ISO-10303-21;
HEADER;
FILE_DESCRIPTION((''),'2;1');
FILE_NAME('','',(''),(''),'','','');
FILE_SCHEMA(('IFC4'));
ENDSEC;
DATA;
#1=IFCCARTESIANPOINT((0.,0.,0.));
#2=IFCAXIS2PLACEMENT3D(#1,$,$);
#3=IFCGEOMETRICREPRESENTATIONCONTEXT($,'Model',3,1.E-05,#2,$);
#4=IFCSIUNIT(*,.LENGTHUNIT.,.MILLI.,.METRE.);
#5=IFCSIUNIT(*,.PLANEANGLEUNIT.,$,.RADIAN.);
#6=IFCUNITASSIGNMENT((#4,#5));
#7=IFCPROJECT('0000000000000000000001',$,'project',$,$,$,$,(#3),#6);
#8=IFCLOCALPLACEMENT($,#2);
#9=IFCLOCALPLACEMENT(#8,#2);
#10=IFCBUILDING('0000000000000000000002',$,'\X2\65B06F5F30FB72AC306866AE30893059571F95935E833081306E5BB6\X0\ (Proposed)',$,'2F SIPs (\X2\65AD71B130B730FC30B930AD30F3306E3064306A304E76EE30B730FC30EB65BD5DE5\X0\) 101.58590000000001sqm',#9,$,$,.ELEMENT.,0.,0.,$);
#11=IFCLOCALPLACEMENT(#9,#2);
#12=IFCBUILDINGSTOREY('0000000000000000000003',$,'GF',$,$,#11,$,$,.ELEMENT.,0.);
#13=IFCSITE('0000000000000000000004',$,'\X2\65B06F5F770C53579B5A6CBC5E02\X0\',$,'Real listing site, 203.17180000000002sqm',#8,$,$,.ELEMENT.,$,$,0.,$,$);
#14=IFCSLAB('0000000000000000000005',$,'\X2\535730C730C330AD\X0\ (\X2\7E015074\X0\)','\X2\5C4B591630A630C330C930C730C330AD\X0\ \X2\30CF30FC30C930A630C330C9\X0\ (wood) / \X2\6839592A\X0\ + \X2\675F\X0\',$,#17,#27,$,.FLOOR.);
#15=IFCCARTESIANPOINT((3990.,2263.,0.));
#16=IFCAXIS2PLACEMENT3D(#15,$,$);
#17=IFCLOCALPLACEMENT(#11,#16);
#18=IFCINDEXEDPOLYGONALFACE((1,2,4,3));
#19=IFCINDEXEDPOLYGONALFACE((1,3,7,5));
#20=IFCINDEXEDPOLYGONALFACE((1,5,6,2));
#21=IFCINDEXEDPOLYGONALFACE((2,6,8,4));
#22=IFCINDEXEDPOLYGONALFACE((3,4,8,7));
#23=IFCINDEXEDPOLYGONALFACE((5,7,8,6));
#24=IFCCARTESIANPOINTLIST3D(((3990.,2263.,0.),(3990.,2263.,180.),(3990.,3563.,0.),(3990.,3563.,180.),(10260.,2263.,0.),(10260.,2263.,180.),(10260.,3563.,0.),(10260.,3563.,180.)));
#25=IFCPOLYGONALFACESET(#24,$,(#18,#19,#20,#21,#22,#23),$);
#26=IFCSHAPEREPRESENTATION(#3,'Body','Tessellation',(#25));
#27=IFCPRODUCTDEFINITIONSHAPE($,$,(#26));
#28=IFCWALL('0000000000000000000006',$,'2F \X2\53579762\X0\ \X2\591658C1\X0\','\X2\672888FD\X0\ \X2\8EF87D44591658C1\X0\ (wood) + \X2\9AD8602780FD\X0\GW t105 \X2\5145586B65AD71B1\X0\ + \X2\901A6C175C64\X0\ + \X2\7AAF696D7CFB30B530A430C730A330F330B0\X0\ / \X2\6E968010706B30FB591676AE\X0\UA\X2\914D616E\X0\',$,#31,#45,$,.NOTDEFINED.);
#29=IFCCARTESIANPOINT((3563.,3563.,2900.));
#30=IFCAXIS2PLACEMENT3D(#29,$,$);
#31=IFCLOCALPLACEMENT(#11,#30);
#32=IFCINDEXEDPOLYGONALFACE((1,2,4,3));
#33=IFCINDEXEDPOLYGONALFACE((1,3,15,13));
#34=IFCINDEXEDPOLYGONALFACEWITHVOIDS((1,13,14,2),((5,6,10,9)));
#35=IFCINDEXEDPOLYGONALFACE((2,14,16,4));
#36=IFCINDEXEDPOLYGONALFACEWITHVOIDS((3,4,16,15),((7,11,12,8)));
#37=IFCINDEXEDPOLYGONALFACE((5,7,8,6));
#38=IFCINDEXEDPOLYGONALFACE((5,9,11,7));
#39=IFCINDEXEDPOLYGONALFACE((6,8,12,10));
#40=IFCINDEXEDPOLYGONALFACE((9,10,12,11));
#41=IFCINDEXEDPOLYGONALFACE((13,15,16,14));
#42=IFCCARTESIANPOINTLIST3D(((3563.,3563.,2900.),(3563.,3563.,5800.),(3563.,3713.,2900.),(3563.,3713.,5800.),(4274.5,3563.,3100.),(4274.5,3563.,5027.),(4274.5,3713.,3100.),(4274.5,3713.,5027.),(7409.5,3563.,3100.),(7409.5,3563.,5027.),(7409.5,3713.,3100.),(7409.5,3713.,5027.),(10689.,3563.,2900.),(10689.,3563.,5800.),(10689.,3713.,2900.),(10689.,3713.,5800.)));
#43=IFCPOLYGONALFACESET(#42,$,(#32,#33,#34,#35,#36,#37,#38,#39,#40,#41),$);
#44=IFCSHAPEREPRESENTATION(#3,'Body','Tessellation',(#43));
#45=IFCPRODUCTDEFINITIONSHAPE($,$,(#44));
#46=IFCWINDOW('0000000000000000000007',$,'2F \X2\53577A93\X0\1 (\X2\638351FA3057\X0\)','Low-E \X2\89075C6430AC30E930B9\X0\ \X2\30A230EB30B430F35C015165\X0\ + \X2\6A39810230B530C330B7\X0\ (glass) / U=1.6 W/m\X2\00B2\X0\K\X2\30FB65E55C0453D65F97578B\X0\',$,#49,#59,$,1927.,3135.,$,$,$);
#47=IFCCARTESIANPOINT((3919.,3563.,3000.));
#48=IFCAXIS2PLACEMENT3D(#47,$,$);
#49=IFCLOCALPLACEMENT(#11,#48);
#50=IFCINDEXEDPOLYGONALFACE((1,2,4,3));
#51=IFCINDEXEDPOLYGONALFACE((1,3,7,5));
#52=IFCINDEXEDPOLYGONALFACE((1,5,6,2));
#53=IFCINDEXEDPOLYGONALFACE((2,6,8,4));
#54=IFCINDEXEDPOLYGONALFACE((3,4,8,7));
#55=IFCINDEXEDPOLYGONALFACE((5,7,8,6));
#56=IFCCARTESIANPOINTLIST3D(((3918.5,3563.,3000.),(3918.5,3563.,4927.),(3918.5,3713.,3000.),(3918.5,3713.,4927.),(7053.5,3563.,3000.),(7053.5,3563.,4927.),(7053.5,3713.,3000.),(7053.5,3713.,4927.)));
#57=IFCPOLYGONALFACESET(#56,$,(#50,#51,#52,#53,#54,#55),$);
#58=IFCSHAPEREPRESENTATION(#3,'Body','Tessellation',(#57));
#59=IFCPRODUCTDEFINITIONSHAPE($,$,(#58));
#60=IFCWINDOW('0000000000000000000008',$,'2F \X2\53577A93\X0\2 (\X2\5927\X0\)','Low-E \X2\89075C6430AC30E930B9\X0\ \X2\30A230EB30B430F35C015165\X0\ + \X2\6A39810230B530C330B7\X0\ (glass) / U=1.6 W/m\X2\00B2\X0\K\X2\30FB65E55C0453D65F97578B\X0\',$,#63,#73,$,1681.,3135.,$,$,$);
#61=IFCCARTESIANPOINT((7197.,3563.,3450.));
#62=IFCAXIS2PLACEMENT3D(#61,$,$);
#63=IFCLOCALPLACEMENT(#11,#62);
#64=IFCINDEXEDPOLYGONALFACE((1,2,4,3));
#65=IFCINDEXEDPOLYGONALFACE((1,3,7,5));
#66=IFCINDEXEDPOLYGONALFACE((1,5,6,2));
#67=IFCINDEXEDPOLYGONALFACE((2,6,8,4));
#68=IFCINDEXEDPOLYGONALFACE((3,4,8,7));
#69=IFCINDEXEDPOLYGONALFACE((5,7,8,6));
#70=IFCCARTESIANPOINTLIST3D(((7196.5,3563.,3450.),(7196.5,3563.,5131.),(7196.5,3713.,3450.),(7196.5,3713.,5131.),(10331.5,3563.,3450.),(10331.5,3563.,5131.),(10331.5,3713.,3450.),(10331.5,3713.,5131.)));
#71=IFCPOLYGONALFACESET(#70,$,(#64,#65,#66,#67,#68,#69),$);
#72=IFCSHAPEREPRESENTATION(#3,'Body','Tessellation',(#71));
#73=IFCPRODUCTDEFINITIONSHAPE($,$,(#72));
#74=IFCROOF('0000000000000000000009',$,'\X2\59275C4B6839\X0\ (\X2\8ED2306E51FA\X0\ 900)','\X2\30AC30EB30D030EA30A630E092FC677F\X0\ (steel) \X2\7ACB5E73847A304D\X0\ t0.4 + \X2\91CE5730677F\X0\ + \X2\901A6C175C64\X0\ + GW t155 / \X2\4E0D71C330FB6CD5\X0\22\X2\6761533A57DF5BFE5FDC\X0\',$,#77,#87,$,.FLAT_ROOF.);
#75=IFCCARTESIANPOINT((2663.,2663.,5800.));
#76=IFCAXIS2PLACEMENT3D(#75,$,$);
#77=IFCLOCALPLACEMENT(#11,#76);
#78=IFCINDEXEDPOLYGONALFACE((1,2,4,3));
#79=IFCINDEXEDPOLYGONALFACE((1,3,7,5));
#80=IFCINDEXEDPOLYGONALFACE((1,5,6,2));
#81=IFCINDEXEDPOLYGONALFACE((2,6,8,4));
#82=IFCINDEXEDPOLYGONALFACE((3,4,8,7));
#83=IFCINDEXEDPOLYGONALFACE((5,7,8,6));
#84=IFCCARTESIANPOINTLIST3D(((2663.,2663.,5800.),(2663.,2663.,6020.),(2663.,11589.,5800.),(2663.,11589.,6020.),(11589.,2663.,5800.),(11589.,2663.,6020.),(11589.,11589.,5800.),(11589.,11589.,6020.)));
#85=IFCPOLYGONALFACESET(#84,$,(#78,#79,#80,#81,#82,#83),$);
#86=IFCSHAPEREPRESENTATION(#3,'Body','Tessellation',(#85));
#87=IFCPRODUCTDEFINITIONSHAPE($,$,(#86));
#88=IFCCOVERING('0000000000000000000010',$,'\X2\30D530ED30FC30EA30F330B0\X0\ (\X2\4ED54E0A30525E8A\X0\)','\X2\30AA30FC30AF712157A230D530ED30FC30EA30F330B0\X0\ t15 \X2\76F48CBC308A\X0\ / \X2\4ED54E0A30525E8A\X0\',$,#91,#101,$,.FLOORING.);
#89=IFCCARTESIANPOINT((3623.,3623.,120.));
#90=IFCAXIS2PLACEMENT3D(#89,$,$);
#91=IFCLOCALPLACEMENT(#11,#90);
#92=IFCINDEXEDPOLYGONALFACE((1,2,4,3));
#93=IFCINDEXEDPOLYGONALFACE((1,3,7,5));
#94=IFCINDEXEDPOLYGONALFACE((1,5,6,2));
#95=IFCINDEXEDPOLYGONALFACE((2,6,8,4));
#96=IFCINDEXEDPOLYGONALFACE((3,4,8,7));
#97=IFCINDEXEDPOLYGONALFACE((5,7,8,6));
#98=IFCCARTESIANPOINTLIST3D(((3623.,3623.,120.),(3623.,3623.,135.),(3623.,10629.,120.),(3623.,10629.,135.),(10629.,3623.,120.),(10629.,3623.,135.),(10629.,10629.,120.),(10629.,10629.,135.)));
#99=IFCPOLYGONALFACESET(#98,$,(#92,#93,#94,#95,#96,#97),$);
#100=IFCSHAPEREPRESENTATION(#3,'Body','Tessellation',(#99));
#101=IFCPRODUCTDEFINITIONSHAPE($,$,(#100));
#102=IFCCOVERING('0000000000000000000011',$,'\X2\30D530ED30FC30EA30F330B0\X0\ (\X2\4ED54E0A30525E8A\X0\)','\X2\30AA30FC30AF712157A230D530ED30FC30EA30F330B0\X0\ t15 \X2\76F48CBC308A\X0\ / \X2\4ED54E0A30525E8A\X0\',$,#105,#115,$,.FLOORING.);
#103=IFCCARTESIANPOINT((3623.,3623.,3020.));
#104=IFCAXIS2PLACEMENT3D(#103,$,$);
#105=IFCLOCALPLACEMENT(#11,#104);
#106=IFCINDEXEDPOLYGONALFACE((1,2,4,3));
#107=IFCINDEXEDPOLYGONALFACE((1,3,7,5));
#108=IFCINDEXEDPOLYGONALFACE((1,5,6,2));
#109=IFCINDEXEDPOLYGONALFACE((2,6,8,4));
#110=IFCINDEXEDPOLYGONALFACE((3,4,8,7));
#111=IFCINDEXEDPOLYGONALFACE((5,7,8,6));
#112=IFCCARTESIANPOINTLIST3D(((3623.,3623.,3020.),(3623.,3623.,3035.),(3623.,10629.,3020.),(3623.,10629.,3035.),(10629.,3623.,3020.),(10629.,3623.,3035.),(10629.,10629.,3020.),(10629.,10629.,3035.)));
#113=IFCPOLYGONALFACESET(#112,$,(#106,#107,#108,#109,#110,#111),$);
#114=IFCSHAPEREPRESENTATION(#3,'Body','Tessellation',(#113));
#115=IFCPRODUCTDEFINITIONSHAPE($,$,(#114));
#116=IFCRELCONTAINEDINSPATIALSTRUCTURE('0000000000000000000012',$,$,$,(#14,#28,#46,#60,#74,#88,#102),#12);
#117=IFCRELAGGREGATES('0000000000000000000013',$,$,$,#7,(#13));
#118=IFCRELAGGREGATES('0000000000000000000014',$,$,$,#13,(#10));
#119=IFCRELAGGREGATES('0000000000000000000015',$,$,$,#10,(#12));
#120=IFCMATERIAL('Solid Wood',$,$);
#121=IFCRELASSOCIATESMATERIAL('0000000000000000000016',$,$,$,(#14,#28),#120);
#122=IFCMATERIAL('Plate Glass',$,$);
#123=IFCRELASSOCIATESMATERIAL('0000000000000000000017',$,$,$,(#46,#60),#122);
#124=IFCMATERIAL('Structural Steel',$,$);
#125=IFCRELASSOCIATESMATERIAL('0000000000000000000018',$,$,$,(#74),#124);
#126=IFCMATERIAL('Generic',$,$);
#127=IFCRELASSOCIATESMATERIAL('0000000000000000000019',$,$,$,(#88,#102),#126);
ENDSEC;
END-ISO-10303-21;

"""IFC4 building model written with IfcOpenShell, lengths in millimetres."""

from ifc_helpers import new_model, si_unit, frame, frame_2d, origin, place, context, project, spatial, rectangle, extrude, material, element, fill, save


model = new_model("IFC4")

# Units and contexts
model_context = context("Model", 3, precision=1e-05, world=origin())
ifc_project = project(units=[si_unit("LENGTHUNIT", "METRE", prefix="MILLI"), si_unit("PLANEANGLEUNIT", "RADIAN")], contexts=[model_context])

# Site, building, storey
site_placement = place(None, origin())
site = spatial("IfcSite", under=ifc_project, at=site_placement, Name="新潟県南魚沼市", ObjectType="Real listing site, 203.17180000000002sqm", CompositionType="ELEMENT", RefElevation=0.0)
building_placement = place(site_placement, origin())
building = spatial("IfcBuilding", under=site, at=building_placement, Name="新潟・犬と暮らす土間広めの家 (Proposed)", ObjectType="2F SIPs (断熱シースキンのつなぎ目シール施工) 101.58590000000001sqm", CompositionType="ELEMENT", ElevationOfRefHeight=0.0, ElevationOfTerrain=0.0)
storey_placement = place(building_placement, origin())
storey = spatial("IfcBuildingStorey", under=building, at=storey_placement, Name="GF", CompositionType="ELEMENT", Elevation=0.0)

# Slab
ifc_material_1 = material(Name="Solid Wood")
slab_1_placement = place(storey_placement, frame((3990.0, 2263.0, 0.0)))
element("IfcSlab", 1, at=slab_1_placement, inside=storey, material=ifc_material_1, Name="南デッキ (縁側)", Description="屋外ウッドデッキ ハードウッド (wood) / 根太 + 束", PredefinedType="FLOOR", context=model_context, shape_type="SweptSolid", body=[
    extrude(rectangle(XDim=6270.0, YDim=1300.0, at=frame_2d((3135.0, 650.0))), frame((3990.0, 2263.0, 0.0)), (0.0, 0.0, 1.0), 180.0),
])

# Shared definitions
ifc_material_2 = material(Name="Plate Glass")

# Wall, openings, windows
wall_1_placement = place(storey_placement, frame((3563.0, 3563.0, 2900.0)))
wall_1 = element("IfcWall", 2, at=wall_1_placement, inside=storey, material=ifc_material_1, Name="2F 南面 外壁", Description="木製 軸組外壁 (wood) + 高性能GW t105 充填断熱 + 通気層 + 窯業系サイディング / 準耐火・外皮UA配慮", PredefinedType="NOTDEFINED", context=model_context, shape_type="SweptSolid", body=[
    extrude(rectangle(XDim=7126.0, YDim=150.0, at=frame_2d((3563.0, 75.0))), frame((3563.0, 3563.0, 2900.0)), (0.0, 0.0, 1.0), 2900.0),
])
opening_1_placement = place(storey_placement, frame((3919.0, 3563.0, 3000.0)))
opening_1 = element("IfcOpeningElement", 3, at=opening_1_placement, cuts=wall_1, PredefinedType="NOTDEFINED", context=model_context, shape_type="SweptSolid", body=[
    extrude(rectangle(XDim=3135.0, YDim=150.0, at=frame_2d((1567.0, 75.0))), frame((3919.0, 3563.0, 3000.0)), (0.0, 0.0, 1.0), 1927.0),
])
opening_2_placement = place(storey_placement, frame((7197.0, 3563.0, 3450.0)))
opening_2 = element("IfcOpeningElement", 4, at=opening_2_placement, cuts=wall_1, PredefinedType="NOTDEFINED", context=model_context, shape_type="SweptSolid", body=[
    extrude(rectangle(XDim=3135.0, YDim=150.0, at=frame_2d((1567.0, 75.0))), frame((7197.0, 3563.0, 3450.0)), (0.0, 0.0, 1.0), 1681.0),
])
window_1_placement = place(storey_placement, frame((3919.0, 3563.0, 3000.0)))
window_1 = element("IfcWindow", 5, at=window_1_placement, inside=storey, material=ifc_material_2, Name="2F 南窓1 (掃出し)", Description="Low-E 複層ガラス アルゴン封入 + 樹脂サッシ (glass) / U=1.6 W/m²K・日射取得型", OverallHeight=1927.0, OverallWidth=3135.0, context=model_context, shape_type="SweptSolid", body=[
    extrude(rectangle(XDim=3135.0, YDim=150.0, at=frame_2d((1567.0, 75.0))), frame((3919.0, 3563.0, 3000.0)), (0.0, 0.0, 1.0), 1927.0),
])
fill(opening_1, window_1)
window_2_placement = place(storey_placement, frame((7197.0, 3563.0, 3450.0)))
window_2 = element("IfcWindow", 6, at=window_2_placement, inside=storey, material=ifc_material_2, Name="2F 南窓2 (大)", Description="Low-E 複層ガラス アルゴン封入 + 樹脂サッシ (glass) / U=1.6 W/m²K・日射取得型", OverallHeight=1681.0, OverallWidth=3135.0, context=model_context, shape_type="SweptSolid", body=[
    extrude(rectangle(XDim=3135.0, YDim=150.0, at=frame_2d((1567.0, 75.0))), frame((7197.0, 3563.0, 3450.0)), (0.0, 0.0, 1.0), 1681.0),
])
fill(opening_2, window_2)

# Roof
ifc_material_3 = material(Name="Structural Steel")
roof_placement = place(storey_placement, frame((2663.0, 2663.0, 5800.0)))
element("IfcRoof", 7, at=roof_placement, inside=storey, material=ifc_material_3, Name="大屋根 (軒の出 900)", Description="ガルバリウム鋼板 (steel) 立平葺き t0.4 + 野地板 + 通気層 + GW t155 / 不燃・法22条区域対応", PredefinedType="FLAT_ROOF", context=model_context, shape_type="SweptSolid", body=[
    extrude(rectangle(XDim=8926.0, YDim=8926.0, at=frame_2d((4463.0, 4463.0))), frame((2663.0, 2663.0, 5800.0)), (0.0, 0.0, 1.0), 220.0),
])

# Coverings
ifc_material_4 = material(Name="Generic")
covering_1_placement = place(storey_placement, frame((3623.0, 3623.0, 120.0)))
element("IfcCovering", 8, at=covering_1_placement, inside=storey, material=ifc_material_4, Name="フローリング (仕上げ床)", Description="オーク無垢フローリング t15 直貼り / 仕上げ床", PredefinedType="FLOORING", context=model_context, shape_type="SweptSolid", body=[
    extrude(rectangle(XDim=7006.0, YDim=7006.0, at=frame_2d((3503.0, 3503.0))), frame((3623.0, 3623.0, 120.0)), (0.0, 0.0, 1.0), 15.0),
])
covering_2_placement = place(storey_placement, frame((3623.0, 3623.0, 3020.0)))
element("IfcCovering", 9, at=covering_2_placement, inside=storey, material=ifc_material_4, Name="フローリング (仕上げ床)", Description="オーク無垢フローリング t15 直貼り / 仕上げ床", PredefinedType="FLOORING", context=model_context, shape_type="SweptSolid", body=[
    extrude(rectangle(XDim=7006.0, YDim=7006.0, at=frame_2d((3503.0, 3503.0))), frame((3623.0, 3623.0, 3020.0)), (0.0, 0.0, 1.0), 15.0),
])

save(model, "model.ifc")
